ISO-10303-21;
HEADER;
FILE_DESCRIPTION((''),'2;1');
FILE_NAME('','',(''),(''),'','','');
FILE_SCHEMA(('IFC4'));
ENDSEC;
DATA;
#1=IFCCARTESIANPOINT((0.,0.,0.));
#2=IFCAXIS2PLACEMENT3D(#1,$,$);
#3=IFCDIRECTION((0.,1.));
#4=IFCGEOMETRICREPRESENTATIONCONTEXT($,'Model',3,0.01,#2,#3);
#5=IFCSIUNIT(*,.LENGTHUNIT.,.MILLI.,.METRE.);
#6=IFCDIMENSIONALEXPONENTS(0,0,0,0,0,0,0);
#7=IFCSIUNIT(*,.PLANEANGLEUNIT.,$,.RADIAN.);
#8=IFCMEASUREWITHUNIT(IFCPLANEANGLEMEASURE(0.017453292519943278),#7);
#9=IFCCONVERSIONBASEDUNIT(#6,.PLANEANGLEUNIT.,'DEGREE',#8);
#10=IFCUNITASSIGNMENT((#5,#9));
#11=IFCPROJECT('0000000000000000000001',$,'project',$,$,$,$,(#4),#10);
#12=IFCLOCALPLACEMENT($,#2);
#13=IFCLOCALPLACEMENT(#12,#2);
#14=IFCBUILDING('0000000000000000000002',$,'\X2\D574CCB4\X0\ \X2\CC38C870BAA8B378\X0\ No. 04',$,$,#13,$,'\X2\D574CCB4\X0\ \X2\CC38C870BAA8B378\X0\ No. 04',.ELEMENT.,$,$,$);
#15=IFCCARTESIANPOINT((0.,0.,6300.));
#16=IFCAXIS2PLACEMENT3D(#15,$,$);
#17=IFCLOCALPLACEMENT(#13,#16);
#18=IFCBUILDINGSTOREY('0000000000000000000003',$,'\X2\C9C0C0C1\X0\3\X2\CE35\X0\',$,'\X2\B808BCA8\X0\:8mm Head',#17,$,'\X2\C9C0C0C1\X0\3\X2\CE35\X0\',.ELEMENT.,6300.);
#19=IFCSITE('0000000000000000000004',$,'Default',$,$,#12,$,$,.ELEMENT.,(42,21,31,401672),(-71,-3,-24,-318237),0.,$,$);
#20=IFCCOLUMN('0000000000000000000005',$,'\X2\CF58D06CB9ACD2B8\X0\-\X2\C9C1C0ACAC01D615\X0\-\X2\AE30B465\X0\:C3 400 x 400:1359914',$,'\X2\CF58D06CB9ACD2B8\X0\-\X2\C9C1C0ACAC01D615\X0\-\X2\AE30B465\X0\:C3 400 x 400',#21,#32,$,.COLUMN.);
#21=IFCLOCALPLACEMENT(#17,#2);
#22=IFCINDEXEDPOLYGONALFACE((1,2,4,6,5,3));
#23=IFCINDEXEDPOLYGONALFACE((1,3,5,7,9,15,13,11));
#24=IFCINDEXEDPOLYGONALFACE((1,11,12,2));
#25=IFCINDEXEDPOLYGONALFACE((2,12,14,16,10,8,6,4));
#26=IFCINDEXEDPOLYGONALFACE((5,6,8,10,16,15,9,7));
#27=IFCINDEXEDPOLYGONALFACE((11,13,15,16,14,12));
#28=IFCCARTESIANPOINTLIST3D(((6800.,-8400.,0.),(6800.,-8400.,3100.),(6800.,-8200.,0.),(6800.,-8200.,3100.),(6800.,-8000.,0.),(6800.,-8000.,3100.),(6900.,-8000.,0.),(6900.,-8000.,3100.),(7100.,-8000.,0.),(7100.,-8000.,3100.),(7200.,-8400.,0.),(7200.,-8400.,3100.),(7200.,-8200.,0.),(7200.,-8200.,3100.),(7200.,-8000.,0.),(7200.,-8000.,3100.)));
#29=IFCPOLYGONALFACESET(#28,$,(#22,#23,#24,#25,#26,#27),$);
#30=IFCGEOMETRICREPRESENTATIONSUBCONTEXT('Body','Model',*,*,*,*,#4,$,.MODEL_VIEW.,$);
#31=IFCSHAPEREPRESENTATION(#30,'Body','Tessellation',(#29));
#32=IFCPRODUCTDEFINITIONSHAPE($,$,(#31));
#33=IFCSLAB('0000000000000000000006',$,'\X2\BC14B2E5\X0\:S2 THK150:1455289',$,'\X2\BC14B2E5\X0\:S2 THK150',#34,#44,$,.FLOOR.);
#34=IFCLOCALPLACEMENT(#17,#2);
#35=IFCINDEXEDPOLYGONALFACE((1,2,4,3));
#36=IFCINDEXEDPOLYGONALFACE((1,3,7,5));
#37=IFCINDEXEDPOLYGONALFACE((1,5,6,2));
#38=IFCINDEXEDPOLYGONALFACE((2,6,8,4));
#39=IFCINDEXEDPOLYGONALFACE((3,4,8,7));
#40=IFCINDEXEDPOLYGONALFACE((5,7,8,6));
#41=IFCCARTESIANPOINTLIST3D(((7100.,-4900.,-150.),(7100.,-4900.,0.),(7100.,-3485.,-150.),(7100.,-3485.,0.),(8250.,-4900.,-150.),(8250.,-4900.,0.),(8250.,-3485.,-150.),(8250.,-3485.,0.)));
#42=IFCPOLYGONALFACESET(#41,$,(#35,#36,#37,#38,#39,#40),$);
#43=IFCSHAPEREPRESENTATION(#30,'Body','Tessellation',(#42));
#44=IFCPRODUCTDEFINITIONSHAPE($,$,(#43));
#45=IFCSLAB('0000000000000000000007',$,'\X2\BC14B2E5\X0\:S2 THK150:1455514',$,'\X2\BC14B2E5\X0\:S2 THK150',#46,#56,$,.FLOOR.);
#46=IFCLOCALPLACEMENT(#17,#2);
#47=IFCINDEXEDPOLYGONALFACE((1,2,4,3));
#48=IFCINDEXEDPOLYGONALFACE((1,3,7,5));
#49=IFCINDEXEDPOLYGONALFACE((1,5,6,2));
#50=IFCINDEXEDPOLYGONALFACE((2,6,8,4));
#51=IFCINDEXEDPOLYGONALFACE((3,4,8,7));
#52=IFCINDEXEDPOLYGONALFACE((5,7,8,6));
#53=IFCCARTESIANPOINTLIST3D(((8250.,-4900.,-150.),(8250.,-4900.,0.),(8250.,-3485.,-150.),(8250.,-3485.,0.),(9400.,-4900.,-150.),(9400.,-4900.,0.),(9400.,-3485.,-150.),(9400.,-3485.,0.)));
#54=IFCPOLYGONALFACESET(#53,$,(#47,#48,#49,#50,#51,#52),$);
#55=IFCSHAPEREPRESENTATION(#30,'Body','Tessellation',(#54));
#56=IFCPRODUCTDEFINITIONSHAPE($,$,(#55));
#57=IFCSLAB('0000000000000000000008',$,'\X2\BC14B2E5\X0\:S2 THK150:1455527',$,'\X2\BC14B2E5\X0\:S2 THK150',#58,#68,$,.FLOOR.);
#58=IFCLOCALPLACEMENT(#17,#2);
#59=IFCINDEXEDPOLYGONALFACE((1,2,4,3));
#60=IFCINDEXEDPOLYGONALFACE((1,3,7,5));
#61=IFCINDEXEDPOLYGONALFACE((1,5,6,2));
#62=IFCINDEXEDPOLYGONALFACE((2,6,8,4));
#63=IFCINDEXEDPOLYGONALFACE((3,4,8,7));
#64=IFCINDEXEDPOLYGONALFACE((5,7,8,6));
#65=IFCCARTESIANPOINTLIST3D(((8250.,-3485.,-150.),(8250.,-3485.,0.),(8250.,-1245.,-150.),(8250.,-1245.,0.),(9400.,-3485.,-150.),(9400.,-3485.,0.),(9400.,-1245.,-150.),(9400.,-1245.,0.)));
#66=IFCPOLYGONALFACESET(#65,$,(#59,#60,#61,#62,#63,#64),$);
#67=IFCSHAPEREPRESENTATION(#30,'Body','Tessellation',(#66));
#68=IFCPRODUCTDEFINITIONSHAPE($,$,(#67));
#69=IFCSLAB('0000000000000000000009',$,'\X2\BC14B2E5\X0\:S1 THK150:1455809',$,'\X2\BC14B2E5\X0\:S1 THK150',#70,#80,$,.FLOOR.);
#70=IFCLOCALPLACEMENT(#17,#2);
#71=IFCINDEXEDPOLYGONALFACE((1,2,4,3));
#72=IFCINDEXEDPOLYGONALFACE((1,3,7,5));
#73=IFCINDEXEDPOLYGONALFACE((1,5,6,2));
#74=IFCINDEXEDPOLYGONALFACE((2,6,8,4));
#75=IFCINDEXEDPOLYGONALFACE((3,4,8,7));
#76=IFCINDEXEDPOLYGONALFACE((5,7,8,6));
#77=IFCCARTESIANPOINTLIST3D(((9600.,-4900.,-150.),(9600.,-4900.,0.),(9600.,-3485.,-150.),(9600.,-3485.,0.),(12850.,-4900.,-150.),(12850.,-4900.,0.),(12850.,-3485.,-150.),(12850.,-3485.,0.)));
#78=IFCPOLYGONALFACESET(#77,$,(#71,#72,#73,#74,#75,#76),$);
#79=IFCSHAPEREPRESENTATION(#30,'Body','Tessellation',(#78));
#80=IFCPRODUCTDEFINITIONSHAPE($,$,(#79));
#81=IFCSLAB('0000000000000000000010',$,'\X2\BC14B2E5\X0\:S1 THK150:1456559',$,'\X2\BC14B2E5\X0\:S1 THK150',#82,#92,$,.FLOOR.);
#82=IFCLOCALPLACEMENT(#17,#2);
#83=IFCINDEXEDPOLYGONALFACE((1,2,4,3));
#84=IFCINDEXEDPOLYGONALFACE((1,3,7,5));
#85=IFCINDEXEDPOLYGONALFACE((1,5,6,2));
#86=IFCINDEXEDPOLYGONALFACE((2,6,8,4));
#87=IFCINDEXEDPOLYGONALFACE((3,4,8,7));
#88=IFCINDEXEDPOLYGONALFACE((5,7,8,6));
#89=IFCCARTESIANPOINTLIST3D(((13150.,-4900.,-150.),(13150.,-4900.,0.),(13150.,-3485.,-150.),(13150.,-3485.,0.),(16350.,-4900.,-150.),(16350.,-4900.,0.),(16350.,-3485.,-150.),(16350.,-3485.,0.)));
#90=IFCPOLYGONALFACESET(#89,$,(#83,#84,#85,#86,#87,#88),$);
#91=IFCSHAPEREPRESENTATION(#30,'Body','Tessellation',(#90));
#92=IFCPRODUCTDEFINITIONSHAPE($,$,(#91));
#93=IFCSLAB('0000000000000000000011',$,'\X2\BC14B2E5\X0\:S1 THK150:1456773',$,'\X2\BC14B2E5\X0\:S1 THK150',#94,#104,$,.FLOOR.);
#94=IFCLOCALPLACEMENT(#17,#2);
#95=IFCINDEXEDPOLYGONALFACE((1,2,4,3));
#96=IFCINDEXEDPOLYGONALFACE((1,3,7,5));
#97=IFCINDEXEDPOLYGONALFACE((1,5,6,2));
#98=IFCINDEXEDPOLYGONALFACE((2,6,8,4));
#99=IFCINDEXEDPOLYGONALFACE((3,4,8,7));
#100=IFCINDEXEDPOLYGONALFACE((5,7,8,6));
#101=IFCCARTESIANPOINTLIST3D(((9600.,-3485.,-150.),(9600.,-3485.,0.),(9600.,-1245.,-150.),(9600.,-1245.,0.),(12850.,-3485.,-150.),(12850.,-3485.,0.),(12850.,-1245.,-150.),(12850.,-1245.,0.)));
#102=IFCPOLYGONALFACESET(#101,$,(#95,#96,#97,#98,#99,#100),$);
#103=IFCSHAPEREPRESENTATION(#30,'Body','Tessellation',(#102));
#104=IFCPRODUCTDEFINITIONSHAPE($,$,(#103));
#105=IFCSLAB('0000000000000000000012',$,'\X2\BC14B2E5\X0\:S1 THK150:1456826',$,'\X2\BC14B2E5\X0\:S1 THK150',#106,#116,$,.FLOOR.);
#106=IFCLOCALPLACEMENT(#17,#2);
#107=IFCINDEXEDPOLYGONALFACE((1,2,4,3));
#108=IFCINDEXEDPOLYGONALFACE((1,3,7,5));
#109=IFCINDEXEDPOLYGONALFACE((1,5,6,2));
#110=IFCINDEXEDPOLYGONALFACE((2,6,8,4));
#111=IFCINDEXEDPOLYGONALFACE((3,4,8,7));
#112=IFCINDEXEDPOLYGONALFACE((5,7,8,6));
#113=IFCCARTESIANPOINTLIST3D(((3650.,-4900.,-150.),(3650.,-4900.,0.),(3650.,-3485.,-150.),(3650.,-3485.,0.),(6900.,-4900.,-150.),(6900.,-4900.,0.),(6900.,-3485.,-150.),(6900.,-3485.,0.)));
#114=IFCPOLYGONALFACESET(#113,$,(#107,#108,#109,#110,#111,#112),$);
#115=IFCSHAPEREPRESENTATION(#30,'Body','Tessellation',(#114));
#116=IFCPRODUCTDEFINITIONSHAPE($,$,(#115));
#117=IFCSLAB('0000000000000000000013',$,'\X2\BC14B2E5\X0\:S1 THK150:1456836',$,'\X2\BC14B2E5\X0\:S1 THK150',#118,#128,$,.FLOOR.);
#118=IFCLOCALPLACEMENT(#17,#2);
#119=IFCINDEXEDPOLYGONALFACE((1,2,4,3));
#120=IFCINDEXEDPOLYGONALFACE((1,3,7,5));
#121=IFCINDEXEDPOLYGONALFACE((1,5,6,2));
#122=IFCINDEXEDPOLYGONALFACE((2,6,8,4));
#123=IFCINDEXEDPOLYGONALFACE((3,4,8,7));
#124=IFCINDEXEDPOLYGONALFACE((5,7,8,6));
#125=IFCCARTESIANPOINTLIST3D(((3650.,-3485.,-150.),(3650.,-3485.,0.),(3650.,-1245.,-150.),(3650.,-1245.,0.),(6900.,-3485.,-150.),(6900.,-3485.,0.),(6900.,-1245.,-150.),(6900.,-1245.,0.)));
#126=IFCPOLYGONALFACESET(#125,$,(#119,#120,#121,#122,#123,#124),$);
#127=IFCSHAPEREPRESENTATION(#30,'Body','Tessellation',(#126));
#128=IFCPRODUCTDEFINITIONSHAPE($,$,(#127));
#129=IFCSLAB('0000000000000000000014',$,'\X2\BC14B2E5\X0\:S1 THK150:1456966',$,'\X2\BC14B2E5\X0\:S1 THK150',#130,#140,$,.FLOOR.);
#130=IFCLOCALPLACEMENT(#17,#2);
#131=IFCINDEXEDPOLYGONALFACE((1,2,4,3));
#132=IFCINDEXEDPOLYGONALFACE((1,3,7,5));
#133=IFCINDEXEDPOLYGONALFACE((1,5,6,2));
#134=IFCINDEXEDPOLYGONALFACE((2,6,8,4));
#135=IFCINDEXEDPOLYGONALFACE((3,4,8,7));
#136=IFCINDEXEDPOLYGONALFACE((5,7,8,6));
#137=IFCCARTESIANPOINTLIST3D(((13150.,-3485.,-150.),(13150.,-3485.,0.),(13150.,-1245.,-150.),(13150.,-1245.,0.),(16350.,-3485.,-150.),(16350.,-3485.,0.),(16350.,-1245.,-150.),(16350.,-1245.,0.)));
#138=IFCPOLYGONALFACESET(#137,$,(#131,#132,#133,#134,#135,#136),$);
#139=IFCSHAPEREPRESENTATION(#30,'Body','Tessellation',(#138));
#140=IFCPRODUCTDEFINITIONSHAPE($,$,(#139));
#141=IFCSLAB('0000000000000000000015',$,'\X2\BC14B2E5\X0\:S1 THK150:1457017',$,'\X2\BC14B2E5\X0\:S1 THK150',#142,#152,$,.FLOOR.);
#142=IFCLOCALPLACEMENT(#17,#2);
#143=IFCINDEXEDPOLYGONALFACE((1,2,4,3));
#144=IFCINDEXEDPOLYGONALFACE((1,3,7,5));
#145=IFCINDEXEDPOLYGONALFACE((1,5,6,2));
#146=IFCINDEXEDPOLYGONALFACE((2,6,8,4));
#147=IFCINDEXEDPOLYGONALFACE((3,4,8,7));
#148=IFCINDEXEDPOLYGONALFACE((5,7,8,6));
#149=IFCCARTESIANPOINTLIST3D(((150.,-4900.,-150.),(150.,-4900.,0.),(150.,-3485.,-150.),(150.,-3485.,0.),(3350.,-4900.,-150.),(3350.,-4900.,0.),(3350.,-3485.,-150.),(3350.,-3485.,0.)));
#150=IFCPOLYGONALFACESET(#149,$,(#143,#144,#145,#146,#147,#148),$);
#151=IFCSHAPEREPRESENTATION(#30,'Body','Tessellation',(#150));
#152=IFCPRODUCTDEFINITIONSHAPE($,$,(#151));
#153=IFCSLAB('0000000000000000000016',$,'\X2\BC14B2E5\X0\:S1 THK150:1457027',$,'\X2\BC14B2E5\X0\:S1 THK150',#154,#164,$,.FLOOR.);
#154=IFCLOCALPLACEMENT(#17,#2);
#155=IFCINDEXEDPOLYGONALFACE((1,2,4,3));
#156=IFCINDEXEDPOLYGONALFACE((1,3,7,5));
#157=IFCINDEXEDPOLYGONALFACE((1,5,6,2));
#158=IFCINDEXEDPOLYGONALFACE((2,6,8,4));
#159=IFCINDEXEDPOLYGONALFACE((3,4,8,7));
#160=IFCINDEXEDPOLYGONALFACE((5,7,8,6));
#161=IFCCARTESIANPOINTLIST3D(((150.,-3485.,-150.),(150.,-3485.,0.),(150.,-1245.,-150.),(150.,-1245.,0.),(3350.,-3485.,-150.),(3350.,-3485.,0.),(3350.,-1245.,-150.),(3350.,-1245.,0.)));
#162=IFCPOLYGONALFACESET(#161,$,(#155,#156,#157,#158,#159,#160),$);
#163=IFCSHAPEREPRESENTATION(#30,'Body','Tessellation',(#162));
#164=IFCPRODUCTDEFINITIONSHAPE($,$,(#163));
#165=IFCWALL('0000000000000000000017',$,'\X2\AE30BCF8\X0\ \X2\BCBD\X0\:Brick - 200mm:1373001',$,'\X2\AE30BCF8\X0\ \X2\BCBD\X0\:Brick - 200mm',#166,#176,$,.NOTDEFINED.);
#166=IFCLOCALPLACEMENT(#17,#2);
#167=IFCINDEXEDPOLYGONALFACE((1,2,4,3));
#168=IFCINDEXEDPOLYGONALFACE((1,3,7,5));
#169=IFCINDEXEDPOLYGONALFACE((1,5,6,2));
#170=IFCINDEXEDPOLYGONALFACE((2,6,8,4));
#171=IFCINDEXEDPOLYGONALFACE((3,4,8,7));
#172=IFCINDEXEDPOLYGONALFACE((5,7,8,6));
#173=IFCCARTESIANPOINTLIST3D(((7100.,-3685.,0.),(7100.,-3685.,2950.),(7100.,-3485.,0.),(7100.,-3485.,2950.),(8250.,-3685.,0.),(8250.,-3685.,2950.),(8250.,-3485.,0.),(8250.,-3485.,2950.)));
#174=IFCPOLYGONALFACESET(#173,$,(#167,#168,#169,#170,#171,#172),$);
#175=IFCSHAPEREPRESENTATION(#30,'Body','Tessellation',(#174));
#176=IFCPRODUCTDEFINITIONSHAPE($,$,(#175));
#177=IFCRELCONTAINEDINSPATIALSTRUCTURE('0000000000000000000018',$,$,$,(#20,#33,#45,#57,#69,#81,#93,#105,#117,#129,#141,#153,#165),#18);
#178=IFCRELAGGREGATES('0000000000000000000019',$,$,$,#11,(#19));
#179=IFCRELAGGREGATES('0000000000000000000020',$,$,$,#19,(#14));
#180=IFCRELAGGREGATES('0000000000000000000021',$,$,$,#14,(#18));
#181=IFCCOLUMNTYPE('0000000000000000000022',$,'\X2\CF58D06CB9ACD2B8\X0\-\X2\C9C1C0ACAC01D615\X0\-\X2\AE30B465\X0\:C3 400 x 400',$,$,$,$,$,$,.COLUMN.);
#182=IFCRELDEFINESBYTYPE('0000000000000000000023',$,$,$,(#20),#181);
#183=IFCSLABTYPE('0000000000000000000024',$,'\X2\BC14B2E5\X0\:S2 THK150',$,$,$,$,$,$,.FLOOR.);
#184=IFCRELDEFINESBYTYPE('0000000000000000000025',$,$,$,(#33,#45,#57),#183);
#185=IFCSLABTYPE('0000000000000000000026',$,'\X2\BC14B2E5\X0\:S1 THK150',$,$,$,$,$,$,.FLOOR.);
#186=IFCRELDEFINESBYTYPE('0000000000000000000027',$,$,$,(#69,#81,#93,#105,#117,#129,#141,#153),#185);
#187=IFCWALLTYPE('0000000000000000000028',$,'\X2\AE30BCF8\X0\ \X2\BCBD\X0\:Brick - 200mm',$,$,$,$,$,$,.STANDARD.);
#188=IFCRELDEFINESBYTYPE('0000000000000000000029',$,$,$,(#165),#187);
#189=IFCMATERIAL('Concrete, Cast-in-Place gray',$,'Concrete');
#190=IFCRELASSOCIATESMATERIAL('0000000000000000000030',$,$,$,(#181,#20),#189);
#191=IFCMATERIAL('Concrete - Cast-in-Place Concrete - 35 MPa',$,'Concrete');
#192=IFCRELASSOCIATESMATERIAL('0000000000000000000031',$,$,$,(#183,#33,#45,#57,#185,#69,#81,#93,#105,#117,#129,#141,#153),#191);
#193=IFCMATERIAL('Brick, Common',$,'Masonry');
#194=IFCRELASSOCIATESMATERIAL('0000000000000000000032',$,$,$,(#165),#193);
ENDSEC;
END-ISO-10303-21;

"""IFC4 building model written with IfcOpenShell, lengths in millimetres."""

from ifc_helpers import new_model, entity, si_unit, converted_unit, direction, frame, origin, place, context, subcontext, project, spatial, indexed_curve, outline, extrude, source, transform, mapped, material, type_object, type_shapes, element, save


model = new_model("IFC4")

# Units and contexts
model_context = context("Model", 3, precision=0.01, world=origin(), true_north=direction((0.0, 1.0)))
body_context = subcontext(model_context, "Body", "Model", "MODEL_VIEW")
ifc_project = project(units=[si_unit("LENGTHUNIT", "METRE", prefix="MILLI"), converted_unit("PLANEANGLEUNIT", "DEGREE", entity("IfcPlaneAngleMeasure", 0.017453292519943278), si_unit("PLANEANGLEUNIT", "RADIAN"), dimensions=[0, 0, 0, 0, 0, 0, 0])], contexts=[model_context])

# Site, building, storey
site_placement = place(None, origin())
site = spatial("IfcSite", under=ifc_project, at=site_placement, Name="Default", CompositionType="ELEMENT", RefLatitude=(42, 21, 31, 401672), RefLongitude=(-71, -3, -24, -318237), RefElevation=0.0)
building_placement = place(site_placement, origin())
building = spatial("IfcBuilding", under=site, at=building_placement, Name="해체 참조모델 No. 04", LongName="해체 참조모델 No. 04", CompositionType="ELEMENT")
storey_placement = place(building_placement, frame((0.0, 0.0, 6300.0)))
storey = spatial("IfcBuildingStorey", under=building, at=storey_placement, Name="지상3층", ObjectType="레벨:8mm Head", LongName="지상3층", CompositionType="ELEMENT", Elevation=6300.0)

# Column
ifc_material_1 = material(Name="Concrete, Cast-in-Place gray", Category="Concrete")
column_type_1 = type_object("IfcColumnType", Name="콘크리트-직사각형-기둥:C3 400 x 400", PredefinedType="COLUMN", material=ifc_material_1)
shared_shape_1 = source(origin(), body_context, "Body", "SweptSolid", [
    extrude(outline(indexed_curve([(-200.0, -150.0), (-100.0, -150.0), (100.0, -150.0), (200.0, -150.0), (200.0, 50.0), (200.0, 250.0), (-200.0, 250.0), (-200.0, 50.0), (-200.0, -150.0)], self_intersect=False)), frame((7000.0, -8150.0, 6300.0), z_axis=(0.0, 0.0, 1.0), x_axis=(-1.0, 0.0, 0.0)), (0.0, 0.0, 1.0), 3100.0),
])
type_shapes(column_type_1, [shared_shape_1])
column_1_placement = place(storey_placement, frame((0.0, 0.0, -6300.0)))
element("IfcColumn", 1, at=column_1_placement, inside=storey, type_object=column_type_1, material=ifc_material_1, Name="콘크리트-직사각형-기둥:C3 400 x 400:1359914", ObjectType="콘크리트-직사각형-기둥:C3 400 x 400", PredefinedType="COLUMN", context=body_context, shape_type="MappedRepresentation", body=[
    mapped(shared_shape_1, transform((0.0, 0.0, 0.0), scale=1.0)),
])

# Slabs
ifc_material_2 = material(Name="Concrete - Cast-in-Place Concrete - 35 MPa", Category="Concrete")
slab_type_1 = type_object("IfcSlabType", Name="바닥:S2 THK150", PredefinedType="FLOOR", material=ifc_material_2)
slab_1_placement = place(storey_placement, origin())
element("IfcSlab", 2, at=slab_1_placement, inside=storey, type_object=slab_type_1, material=ifc_material_2, Name="바닥:S2 THK150:1455289", ObjectType="바닥:S2 THK150", PredefinedType="FLOOR", context=body_context, shape_type="SweptSolid", body=[
    extrude(outline(indexed_curve([(-707.5, -575.0), (707.5, -575.0), (707.5, 575.0), (-707.5, 575.0), (-707.5, -575.0)], self_intersect=False)), frame((7675.0, -4192.5, 0.0), z_axis=(0.0, 0.0, -1.0), x_axis=(0.0, 1.0, 0.0)), (0.0, 0.0, 1.0), 150.0),
])
slab_2_placement = place(storey_placement, origin())
element("IfcSlab", 3, at=slab_2_placement, inside=storey, type_object=slab_type_1, material=ifc_material_2, Name="바닥:S2 THK150:1455514", ObjectType="바닥:S2 THK150", PredefinedType="FLOOR", context=body_context, shape_type="SweptSolid", body=[
    extrude(outline(indexed_curve([(-707.5, -575.0), (707.5, -575.0), (707.5, 575.0), (-707.5, 575.0), (-707.5, -575.0)], self_intersect=False)), frame((8825.0, -4192.5, 0.0), z_axis=(0.0, 0.0, -1.0), x_axis=(0.0, 1.0, 0.0)), (0.0, 0.0, 1.0), 150.0),
])
slab_3_placement = place(storey_placement, origin())
element("IfcSlab", 4, at=slab_3_placement, inside=storey, type_object=slab_type_1, material=ifc_material_2, Name="바닥:S2 THK150:1455527", ObjectType="바닥:S2 THK150", PredefinedType="FLOOR", context=body_context, shape_type="SweptSolid", body=[
    extrude(outline(indexed_curve([(-1120.0, -575.0), (1120.0, -575.0), (1120.0, 575.0), (-1120.0, 575.0), (-1120.0, -575.0)], self_intersect=False)), frame((8825.0, -2365.0, 0.0), z_axis=(0.0, 0.0, -1.0), x_axis=(0.0, 1.0, 0.0)), (0.0, 0.0, 1.0), 150.0),
])
slab_type_2 = type_object("IfcSlabType", Name="바닥:S1 THK150", PredefinedType="FLOOR", material=ifc_material_2)
slab_4_placement = place(storey_placement, origin())
element("IfcSlab", 5, at=slab_4_placement, inside=storey, type_object=slab_type_2, material=ifc_material_2, Name="바닥:S1 THK150:1455809", ObjectType="바닥:S1 THK150", PredefinedType="FLOOR", context=body_context, shape_type="SweptSolid", body=[
    extrude(outline(indexed_curve([(-707.5, -1625.0), (707.5, -1625.0), (707.5, 1625.0), (-707.5, 1625.0), (-707.5, -1625.0)], self_intersect=False)), frame((11225.0, -4192.5, 0.0), z_axis=(0.0, 0.0, -1.0), x_axis=(0.0, 1.0, 0.0)), (0.0, 0.0, 1.0), 150.0),
])
slab_5_placement = place(storey_placement, origin())
element("IfcSlab", 6, at=slab_5_placement, inside=storey, type_object=slab_type_2, material=ifc_material_2, Name="바닥:S1 THK150:1456559", ObjectType="바닥:S1 THK150", PredefinedType="FLOOR", context=body_context, shape_type="SweptSolid", body=[
    extrude(outline(indexed_curve([(-707.5, -1600.0), (707.5, -1600.0), (707.5, 1600.0), (-707.5, 1600.0), (-707.5, -1600.0)], self_intersect=False)), frame((14750.0, -4192.5, 0.0), z_axis=(0.0, 0.0, -1.0), x_axis=(0.0, 1.0, 0.0)), (0.0, 0.0, 1.0), 150.0),
])
slab_6_placement = place(storey_placement, origin())
element("IfcSlab", 7, at=slab_6_placement, inside=storey, type_object=slab_type_2, material=ifc_material_2, Name="바닥:S1 THK150:1456773", ObjectType="바닥:S1 THK150", PredefinedType="FLOOR", context=body_context, shape_type="SweptSolid", body=[
    extrude(outline(indexed_curve([(-1120.0, -1625.0), (1120.0, -1625.0), (1120.0, 1625.0), (-1120.0, 1625.0), (-1120.0, -1625.0)], self_intersect=False)), frame((11225.0, -2365.0, 0.0), z_axis=(0.0, 0.0, -1.0), x_axis=(0.0, 1.0, 0.0)), (0.0, 0.0, 1.0), 150.0),
])
slab_7_placement = place(storey_placement, origin())
element("IfcSlab", 8, at=slab_7_placement, inside=storey, type_object=slab_type_2, material=ifc_material_2, Name="바닥:S1 THK150:1456826", ObjectType="바닥:S1 THK150", PredefinedType="FLOOR", context=body_context, shape_type="SweptSolid", body=[
    extrude(outline(indexed_curve([(-707.5, -1625.0), (707.5, -1625.0), (707.5, 1625.0), (-707.5, 1625.0), (-707.5, -1625.0)], self_intersect=False)), frame((5275.0, -4192.5, 0.0), z_axis=(0.0, 0.0, -1.0), x_axis=(0.0, 1.0, 0.0)), (0.0, 0.0, 1.0), 150.0),
])
slab_8_placement = place(storey_placement, origin())
element("IfcSlab", 9, at=slab_8_placement, inside=storey, type_object=slab_type_2, material=ifc_material_2, Name="바닥:S1 THK150:1456836", ObjectType="바닥:S1 THK150", PredefinedType="FLOOR", context=body_context, shape_type="SweptSolid", body=[
    extrude(outline(indexed_curve([(-1120.0, -1625.0), (1120.0, -1625.0), (1120.0, 1625.0), (-1120.0, 1625.0), (-1120.0, -1625.0)], self_intersect=False)), frame((5275.0, -2365.0, 0.0), z_axis=(0.0, 0.0, -1.0), x_axis=(0.0, 1.0, 0.0)), (0.0, 0.0, 1.0), 150.0),
])
slab_9_placement = place(storey_placement, origin())
element("IfcSlab", 10, at=slab_9_placement, inside=storey, type_object=slab_type_2, material=ifc_material_2, Name="바닥:S1 THK150:1456966", ObjectType="바닥:S1 THK150", PredefinedType="FLOOR", context=body_context, shape_type="SweptSolid", body=[
    extrude(outline(indexed_curve([(-1120.0, -1600.0), (1120.0, -1600.0), (1120.0, 1600.0), (-1120.0, 1600.0), (-1120.0, -1600.0)], self_intersect=False)), frame((14750.0, -2365.0, 0.0), z_axis=(0.0, 0.0, -1.0), x_axis=(0.0, 1.0, 0.0)), (0.0, 0.0, 1.0), 150.0),
])
slab_10_placement = place(storey_placement, origin())
element("IfcSlab", 11, at=slab_10_placement, inside=storey, type_object=slab_type_2, material=ifc_material_2, Name="바닥:S1 THK150:1457017", ObjectType="바닥:S1 THK150", PredefinedType="FLOOR", context=body_context, shape_type="SweptSolid", body=[
    extrude(outline(indexed_curve([(-707.5, -1600.0), (707.5, -1600.0), (707.5, 1600.0), (-707.5, 1600.0), (-707.5, -1600.0)], self_intersect=False)), frame((1750.0, -4192.5, 0.0), z_axis=(0.0, 0.0, -1.0), x_axis=(0.0, 1.0, 0.0)), (0.0, 0.0, 1.0), 150.0),
])
slab_11_placement = place(storey_placement, origin())
element("IfcSlab", 12, at=slab_11_placement, inside=storey, type_object=slab_type_2, material=ifc_material_2, Name="바닥:S1 THK150:1457027", ObjectType="바닥:S1 THK150", PredefinedType="FLOOR", context=body_context, shape_type="SweptSolid", body=[
    extrude(outline(indexed_curve([(-1120.0, -1600.0), (1120.0, -1600.0), (1120.0, 1600.0), (-1120.0, 1600.0), (-1120.0, -1600.0)], self_intersect=False)), frame((1750.0, -2365.0, 0.0), z_axis=(0.0, 0.0, -1.0), x_axis=(0.0, 1.0, 0.0)), (0.0, 0.0, 1.0), 150.0),
])

# Wall
ifc_material_3 = material(Name="Brick, Common", Category="Masonry")
wall_type = type_object("IfcWallType", Name="기본 벽:Brick - 200mm", PredefinedType="STANDARD")
wall_1_placement = place(storey_placement, frame((8250.0, -3585.0, 0.0), z_axis=(0.0, 0.0, 1.0), x_axis=(-1.0, 0.0, 0.0)))
element("IfcWall", 13, at=wall_1_placement, inside=storey, type_object=wall_type, material=ifc_material_3, Name="기본 벽:Brick - 200mm:1373001", ObjectType="기본 벽:Brick - 200mm", PredefinedType="NOTDEFINED", context=body_context, shape_type="SweptSolid", body=[
    extrude(outline(indexed_curve([(1150.0, 100.0), (0.0, 100.0), (0.0, -100.0), (1150.0, -100.0), (1150.0, 100.0)], self_intersect=False)), origin(), (0.0, 0.0, 1.0), 2950.0),
])

save(model, "model.ifc")
